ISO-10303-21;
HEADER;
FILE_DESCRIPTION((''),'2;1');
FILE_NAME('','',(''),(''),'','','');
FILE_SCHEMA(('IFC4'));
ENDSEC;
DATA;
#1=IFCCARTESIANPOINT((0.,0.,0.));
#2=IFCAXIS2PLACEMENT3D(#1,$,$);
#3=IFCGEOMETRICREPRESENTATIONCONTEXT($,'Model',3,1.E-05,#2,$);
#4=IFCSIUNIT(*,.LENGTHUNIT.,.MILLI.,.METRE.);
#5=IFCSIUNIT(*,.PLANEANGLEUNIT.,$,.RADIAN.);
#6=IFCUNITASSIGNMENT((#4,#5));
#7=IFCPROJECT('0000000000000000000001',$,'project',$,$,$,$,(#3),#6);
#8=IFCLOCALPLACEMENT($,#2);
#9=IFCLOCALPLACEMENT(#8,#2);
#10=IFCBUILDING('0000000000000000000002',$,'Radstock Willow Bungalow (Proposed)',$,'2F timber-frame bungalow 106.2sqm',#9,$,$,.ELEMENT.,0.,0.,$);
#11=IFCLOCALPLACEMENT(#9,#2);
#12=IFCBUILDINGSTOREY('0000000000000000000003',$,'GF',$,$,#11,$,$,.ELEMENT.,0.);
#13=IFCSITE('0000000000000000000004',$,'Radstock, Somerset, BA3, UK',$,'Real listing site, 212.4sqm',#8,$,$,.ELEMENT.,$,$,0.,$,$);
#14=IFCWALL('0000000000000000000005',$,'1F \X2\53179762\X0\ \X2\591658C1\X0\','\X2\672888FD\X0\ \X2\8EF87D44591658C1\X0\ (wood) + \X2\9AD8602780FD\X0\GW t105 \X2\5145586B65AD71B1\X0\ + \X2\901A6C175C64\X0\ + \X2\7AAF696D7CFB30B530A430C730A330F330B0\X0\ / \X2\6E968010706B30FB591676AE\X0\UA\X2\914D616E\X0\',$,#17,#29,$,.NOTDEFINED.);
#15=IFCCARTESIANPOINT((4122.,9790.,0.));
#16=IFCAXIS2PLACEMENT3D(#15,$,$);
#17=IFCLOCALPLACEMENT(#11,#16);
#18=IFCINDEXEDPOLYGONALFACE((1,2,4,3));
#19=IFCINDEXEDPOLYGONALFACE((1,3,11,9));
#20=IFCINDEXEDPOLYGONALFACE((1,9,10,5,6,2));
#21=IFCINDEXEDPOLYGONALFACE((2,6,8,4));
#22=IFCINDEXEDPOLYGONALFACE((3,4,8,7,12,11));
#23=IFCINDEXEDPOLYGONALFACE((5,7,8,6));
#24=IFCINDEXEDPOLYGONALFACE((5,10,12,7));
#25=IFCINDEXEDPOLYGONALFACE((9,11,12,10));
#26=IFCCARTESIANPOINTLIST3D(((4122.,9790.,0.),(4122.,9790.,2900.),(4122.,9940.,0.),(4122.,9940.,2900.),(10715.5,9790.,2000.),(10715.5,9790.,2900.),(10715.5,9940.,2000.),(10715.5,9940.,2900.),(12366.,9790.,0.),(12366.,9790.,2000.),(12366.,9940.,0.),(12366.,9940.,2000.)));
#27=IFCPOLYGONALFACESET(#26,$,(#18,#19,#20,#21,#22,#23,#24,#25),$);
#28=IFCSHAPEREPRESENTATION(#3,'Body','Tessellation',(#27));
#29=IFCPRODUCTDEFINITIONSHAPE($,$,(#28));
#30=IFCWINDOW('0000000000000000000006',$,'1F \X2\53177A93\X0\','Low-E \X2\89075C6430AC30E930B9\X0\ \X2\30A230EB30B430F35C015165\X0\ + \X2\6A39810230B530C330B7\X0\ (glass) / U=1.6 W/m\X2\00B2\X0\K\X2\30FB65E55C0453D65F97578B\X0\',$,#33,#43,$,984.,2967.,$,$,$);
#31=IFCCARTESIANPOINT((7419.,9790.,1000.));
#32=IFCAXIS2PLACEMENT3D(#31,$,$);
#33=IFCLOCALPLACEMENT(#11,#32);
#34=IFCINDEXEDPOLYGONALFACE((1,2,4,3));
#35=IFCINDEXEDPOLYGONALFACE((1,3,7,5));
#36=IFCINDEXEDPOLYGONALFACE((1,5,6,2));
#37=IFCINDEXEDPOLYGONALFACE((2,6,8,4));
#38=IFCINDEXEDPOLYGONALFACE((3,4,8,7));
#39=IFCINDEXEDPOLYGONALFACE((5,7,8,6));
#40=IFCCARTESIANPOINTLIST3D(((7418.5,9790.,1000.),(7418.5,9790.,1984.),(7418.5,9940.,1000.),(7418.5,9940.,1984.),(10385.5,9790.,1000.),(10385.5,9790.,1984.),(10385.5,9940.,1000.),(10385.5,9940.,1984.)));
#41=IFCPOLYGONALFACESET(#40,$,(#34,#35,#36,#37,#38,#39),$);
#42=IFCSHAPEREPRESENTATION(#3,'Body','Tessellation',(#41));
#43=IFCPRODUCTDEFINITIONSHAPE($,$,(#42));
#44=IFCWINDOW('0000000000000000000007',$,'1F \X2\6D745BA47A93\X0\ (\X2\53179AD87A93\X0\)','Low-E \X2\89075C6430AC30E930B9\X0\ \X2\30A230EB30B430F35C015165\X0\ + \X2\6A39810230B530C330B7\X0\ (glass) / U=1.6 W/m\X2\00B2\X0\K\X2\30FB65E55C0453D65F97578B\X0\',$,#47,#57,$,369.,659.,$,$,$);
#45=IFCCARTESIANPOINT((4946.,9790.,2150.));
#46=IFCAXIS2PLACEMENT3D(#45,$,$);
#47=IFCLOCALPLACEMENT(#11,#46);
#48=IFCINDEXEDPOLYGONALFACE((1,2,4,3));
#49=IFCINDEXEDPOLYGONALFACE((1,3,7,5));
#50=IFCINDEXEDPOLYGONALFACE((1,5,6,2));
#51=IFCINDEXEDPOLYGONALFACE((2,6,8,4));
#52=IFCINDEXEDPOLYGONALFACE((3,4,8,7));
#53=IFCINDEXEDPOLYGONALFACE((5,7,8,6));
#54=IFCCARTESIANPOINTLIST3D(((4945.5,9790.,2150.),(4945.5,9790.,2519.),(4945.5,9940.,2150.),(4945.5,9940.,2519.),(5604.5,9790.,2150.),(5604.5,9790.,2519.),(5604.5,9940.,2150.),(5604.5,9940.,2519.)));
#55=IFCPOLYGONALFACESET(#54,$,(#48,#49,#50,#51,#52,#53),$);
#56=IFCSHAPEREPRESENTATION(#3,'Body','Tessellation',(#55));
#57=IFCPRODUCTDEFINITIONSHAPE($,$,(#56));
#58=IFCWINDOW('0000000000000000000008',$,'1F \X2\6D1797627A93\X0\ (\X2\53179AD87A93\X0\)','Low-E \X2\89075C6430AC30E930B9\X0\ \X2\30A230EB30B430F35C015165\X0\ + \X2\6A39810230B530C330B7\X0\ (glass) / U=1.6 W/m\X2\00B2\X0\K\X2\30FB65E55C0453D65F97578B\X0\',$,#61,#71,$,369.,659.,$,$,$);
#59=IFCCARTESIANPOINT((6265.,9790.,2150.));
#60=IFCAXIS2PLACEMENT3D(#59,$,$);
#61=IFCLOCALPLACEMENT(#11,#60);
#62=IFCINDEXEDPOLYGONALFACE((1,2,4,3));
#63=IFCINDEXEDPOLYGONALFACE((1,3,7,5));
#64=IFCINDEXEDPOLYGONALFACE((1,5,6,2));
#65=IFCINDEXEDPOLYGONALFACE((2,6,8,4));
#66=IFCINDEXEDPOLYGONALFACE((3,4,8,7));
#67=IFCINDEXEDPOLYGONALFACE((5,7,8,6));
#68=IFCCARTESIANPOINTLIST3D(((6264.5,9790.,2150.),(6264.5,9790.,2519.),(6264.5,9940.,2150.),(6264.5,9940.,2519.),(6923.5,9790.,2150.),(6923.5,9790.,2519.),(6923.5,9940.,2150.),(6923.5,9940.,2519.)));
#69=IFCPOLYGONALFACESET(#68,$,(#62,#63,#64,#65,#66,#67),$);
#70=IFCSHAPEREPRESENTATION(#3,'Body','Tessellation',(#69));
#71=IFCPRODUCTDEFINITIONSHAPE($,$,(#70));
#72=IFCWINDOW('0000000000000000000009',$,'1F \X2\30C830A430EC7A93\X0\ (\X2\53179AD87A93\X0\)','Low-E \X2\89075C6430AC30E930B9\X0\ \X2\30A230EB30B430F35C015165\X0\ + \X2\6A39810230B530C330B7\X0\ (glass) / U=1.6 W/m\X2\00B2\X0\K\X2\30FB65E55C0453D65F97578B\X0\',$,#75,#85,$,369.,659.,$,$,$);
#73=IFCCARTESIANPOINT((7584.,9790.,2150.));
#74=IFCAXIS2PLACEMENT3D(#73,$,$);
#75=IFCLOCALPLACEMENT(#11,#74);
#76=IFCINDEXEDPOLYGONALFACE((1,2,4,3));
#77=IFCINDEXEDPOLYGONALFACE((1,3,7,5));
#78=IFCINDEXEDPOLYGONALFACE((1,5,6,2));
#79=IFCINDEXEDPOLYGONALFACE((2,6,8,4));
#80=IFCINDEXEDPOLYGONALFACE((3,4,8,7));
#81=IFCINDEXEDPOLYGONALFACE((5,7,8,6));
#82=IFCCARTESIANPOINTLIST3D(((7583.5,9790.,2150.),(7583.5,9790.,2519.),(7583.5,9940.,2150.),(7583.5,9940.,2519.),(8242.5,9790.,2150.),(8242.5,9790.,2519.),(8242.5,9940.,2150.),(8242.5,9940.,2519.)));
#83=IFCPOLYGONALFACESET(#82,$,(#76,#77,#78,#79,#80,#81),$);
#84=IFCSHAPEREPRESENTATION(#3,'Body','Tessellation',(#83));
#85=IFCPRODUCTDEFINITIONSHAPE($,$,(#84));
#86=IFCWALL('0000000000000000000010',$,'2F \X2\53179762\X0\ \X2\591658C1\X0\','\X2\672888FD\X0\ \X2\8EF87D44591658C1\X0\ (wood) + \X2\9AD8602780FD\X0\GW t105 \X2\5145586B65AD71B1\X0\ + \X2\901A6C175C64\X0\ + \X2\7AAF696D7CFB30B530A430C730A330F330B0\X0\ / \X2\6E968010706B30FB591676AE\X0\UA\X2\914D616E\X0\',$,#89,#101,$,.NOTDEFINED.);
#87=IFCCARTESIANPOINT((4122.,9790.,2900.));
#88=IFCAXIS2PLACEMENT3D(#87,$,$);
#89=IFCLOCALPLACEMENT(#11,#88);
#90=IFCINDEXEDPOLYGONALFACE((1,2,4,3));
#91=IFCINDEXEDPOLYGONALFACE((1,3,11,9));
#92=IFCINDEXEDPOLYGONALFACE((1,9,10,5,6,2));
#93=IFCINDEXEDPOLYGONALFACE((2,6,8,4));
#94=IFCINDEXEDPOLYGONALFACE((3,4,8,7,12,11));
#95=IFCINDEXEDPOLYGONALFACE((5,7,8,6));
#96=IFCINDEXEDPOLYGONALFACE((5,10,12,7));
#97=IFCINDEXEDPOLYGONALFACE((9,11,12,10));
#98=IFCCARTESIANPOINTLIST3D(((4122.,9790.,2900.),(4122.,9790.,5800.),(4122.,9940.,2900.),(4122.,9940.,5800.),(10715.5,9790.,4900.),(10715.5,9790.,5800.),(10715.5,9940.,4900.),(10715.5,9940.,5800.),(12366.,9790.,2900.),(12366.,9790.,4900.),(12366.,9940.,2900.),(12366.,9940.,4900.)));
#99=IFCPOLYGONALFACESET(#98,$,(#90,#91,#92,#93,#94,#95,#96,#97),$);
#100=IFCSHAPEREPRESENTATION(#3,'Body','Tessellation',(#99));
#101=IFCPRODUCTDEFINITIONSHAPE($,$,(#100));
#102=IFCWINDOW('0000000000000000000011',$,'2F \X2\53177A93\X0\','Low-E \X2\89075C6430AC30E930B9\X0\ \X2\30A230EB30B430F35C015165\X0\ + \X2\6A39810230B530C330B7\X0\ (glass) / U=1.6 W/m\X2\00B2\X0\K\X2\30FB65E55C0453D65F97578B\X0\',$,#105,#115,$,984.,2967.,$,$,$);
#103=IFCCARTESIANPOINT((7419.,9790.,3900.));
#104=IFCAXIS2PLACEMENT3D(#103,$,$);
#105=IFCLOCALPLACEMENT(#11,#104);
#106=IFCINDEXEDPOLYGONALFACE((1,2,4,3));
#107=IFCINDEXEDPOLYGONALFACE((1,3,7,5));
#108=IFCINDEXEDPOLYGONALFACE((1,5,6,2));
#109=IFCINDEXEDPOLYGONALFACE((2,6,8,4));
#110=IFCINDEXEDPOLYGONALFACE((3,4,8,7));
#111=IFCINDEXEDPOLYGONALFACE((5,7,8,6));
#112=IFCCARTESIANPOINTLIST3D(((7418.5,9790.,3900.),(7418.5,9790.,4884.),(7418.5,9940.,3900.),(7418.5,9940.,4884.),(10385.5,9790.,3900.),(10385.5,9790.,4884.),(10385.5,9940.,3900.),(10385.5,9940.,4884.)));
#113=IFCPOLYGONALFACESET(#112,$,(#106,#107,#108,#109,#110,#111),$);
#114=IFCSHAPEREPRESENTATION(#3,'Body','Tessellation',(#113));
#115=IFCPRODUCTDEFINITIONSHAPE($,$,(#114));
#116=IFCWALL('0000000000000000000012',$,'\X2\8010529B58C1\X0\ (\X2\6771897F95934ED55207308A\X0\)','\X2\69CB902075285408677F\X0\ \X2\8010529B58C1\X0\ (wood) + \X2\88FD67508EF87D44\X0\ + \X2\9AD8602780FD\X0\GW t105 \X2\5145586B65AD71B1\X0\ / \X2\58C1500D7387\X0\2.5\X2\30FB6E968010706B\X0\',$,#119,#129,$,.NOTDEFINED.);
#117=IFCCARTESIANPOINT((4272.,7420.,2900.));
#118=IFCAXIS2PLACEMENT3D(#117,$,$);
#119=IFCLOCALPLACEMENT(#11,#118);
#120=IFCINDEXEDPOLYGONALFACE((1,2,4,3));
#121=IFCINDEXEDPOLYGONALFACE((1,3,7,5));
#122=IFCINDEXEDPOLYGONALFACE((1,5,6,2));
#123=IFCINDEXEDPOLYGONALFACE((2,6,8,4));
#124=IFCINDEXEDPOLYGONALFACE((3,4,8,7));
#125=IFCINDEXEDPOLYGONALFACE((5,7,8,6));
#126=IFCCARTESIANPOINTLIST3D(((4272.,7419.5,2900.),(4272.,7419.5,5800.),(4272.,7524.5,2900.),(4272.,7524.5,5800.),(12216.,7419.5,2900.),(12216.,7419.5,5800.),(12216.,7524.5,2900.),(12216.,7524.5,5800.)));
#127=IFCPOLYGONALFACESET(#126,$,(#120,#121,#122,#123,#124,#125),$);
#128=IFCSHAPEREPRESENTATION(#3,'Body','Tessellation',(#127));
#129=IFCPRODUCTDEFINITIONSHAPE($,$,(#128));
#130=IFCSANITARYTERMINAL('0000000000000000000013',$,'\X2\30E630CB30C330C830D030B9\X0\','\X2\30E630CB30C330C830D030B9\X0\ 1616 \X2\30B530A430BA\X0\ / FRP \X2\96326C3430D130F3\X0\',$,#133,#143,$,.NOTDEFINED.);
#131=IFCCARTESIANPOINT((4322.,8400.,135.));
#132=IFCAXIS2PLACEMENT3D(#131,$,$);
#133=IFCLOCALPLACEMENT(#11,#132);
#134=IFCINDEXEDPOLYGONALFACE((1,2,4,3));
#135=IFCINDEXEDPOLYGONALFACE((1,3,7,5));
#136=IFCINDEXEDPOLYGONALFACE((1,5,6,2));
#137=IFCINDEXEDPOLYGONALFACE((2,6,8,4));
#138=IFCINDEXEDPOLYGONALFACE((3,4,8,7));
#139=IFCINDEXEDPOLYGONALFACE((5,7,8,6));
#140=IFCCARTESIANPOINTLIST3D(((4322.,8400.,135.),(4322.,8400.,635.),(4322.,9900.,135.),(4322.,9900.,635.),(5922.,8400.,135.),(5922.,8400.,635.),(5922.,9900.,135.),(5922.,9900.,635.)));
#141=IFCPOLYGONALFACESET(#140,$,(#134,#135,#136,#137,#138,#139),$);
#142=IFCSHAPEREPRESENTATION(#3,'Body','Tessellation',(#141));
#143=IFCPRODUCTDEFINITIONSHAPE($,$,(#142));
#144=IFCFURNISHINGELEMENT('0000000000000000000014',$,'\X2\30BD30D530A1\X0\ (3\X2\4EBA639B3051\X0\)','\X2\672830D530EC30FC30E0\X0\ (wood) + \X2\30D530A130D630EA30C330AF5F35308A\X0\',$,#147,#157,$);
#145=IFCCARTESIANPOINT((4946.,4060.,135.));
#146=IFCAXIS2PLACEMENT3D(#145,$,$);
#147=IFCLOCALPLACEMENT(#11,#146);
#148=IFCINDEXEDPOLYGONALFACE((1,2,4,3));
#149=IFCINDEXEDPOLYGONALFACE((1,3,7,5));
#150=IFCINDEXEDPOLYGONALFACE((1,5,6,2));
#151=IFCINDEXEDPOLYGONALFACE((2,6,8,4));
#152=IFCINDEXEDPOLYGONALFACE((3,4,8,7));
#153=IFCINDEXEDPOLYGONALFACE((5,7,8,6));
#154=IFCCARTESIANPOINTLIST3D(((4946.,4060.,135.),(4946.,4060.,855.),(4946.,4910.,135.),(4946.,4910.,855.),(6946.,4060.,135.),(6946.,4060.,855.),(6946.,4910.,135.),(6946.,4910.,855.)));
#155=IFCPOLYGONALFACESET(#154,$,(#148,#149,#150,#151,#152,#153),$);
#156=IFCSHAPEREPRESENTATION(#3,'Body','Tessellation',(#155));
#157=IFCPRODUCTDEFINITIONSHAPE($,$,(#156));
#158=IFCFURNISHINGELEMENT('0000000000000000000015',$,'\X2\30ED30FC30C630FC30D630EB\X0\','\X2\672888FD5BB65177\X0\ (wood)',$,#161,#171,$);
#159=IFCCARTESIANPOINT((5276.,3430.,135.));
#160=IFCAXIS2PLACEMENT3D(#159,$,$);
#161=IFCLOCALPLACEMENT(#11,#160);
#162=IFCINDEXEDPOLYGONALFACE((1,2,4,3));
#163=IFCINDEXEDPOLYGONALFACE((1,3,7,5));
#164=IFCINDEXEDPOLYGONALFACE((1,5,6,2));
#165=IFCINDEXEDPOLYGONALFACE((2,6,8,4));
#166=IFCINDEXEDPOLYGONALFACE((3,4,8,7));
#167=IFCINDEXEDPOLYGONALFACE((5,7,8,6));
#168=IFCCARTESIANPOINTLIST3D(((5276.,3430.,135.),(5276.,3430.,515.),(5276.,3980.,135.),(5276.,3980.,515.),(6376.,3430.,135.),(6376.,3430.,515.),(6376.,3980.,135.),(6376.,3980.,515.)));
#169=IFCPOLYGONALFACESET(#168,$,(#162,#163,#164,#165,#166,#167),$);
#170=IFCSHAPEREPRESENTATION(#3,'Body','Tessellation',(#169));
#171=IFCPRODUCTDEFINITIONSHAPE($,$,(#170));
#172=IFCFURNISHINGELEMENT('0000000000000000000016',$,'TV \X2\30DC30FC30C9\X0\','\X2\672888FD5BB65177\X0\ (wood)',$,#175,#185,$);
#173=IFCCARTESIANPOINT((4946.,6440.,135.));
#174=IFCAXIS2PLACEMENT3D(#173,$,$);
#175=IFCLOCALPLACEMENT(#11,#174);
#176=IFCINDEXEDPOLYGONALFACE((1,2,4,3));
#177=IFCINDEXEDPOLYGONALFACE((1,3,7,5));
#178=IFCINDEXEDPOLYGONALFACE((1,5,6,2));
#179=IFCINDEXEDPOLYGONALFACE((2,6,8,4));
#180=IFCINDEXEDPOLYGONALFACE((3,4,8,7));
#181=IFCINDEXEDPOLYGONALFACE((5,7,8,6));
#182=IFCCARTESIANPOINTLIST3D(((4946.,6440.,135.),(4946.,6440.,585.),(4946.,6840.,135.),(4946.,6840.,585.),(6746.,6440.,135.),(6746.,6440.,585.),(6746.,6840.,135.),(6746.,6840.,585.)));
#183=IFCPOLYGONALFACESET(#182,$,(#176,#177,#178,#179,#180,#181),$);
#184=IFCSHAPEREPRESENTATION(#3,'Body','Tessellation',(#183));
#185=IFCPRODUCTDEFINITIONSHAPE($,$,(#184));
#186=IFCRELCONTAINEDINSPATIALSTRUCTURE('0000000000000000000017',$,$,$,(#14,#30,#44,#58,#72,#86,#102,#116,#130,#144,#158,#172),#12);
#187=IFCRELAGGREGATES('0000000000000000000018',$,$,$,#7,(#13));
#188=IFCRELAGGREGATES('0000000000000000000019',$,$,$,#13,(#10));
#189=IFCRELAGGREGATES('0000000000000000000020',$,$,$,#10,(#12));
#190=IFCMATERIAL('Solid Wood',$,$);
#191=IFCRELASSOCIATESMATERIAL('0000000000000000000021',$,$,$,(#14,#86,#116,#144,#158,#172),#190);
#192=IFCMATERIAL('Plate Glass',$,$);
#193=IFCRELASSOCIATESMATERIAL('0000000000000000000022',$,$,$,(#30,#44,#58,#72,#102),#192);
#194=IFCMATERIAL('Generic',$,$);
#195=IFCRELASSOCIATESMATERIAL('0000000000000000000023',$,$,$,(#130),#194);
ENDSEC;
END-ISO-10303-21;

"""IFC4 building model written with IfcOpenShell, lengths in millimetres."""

from ifc_helpers import new_model, si_unit, frame, frame_2d, origin, place, context, project, spatial, rectangle, extrude, material, element, fill, save


model = new_model("IFC4")

# Units and contexts
model_context = context("Model", 3, precision=1e-05, world=origin())
ifc_project = project(units=[si_unit("LENGTHUNIT", "METRE", prefix="MILLI"), si_unit("PLANEANGLEUNIT", "RADIAN")], contexts=[model_context])

# Site, building, storey
site_placement = place(None, origin())
site = spatial("IfcSite", under=ifc_project, at=site_placement, Name="Radstock, Somerset, BA3, UK", ObjectType="Real listing site, 212.4sqm", CompositionType="ELEMENT", RefElevation=0.0)
building_placement = place(site_placement, origin())
building = spatial("IfcBuilding", under=site, at=building_placement, Name="Radstock Willow Bungalow (Proposed)", ObjectType="2F timber-frame bungalow 106.2sqm", CompositionType="ELEMENT", ElevationOfRefHeight=0.0, ElevationOfTerrain=0.0)
storey_placement = place(building_placement, origin())
storey = spatial("IfcBuildingStorey", under=building, at=storey_placement, Name="GF", CompositionType="ELEMENT", Elevation=0.0)

# Wall, openings, windows
ifc_material_1 = material(Name="Solid Wood")
wall_1_placement = place(storey_placement, frame((4122.0, 9790.0, 0.0)))
wall_1 = element("IfcWall", 1, at=wall_1_placement, inside=storey, material=ifc_material_1, Name="1F 北面 外壁", Description="木製 軸組外壁 (wood) + 高性能GW t105 充填断熱 + 通気層 + 窯業系サイディング / 準耐火・外皮UA配慮", PredefinedType="NOTDEFINED", context=model_context, shape_type="SweptSolid", body=[
    extrude(rectangle(XDim=8244.0, YDim=150.0, at=frame_2d((4122.0, 75.0))), frame((4122.0, 9790.0, 0.0)), (0.0, 0.0, 1.0), 2900.0),
])
opening_1_placement = place(storey_placement, frame((7419.0, 9790.0, 1000.0)))
opening_1 = element("IfcOpeningElement", 2, at=opening_1_placement, cuts=wall_1, PredefinedType="NOTDEFINED", context=model_context, shape_type="SweptSolid", body=[
    extrude(rectangle(XDim=2967.0, YDim=150.0, at=frame_2d((1483.0, 75.0))), frame((7419.0, 9790.0, 1000.0)), (0.0, 0.0, 1.0), 984.0),
])
opening_2_placement = place(storey_placement, frame((4946.0, 9790.0, 2150.0)))
opening_2 = element("IfcOpeningElement", 3, at=opening_2_placement, cuts=wall_1, PredefinedType="NOTDEFINED", context=model_context, shape_type="SweptSolid", body=[
    extrude(rectangle(XDim=659.0, YDim=150.0, at=frame_2d((329.0, 75.0))), frame((4946.0, 9790.0, 2150.0)), (0.0, 0.0, 1.0), 369.0),
])
opening_3_placement = place(storey_placement, frame((6265.0, 9790.0, 2150.0)))
opening_3 = element("IfcOpeningElement", 4, at=opening_3_placement, cuts=wall_1, PredefinedType="NOTDEFINED", context=model_context, shape_type="SweptSolid", body=[
    extrude(rectangle(XDim=659.0, YDim=150.0, at=frame_2d((329.0, 75.0))), frame((6265.0, 9790.0, 2150.0)), (0.0, 0.0, 1.0), 369.0),
])
opening_4_placement = place(storey_placement, frame((7584.0, 9790.0, 2150.0)))
opening_4 = element("IfcOpeningElement", 5, at=opening_4_placement, cuts=wall_1, PredefinedType="NOTDEFINED", context=model_context, shape_type="SweptSolid", body=[
    extrude(rectangle(XDim=659.0, YDim=150.0, at=frame_2d((329.0, 75.0))), frame((7584.0, 9790.0, 2150.0)), (0.0, 0.0, 1.0), 369.0),
])
ifc_material_2 = material(Name="Plate Glass")
window_1_placement = place(storey_placement, frame((7419.0, 9790.0, 1000.0)))
window_1 = element("IfcWindow", 6, at=window_1_placement, inside=storey, material=ifc_material_2, Name="1F 北窓", Description="Low-E 複層ガラス アルゴン封入 + 樹脂サッシ (glass) / U=1.6 W/m²K・日射取得型", OverallHeight=984.0, OverallWidth=2967.0, context=model_context, shape_type="SweptSolid", body=[
    extrude(rectangle(XDim=2967.0, YDim=150.0, at=frame_2d((1483.0, 75.0))), frame((7419.0, 9790.0, 1000.0)), (0.0, 0.0, 1.0), 984.0),
])
fill(opening_1, window_1)
window_2_placement = place(storey_placement, frame((4946.0, 9790.0, 2150.0)))
window_2 = element("IfcWindow", 7, at=window_2_placement, inside=storey, material=ifc_material_2, Name="1F 浴室窓 (北高窓)", Description="Low-E 複層ガラス アルゴン封入 + 樹脂サッシ (glass) / U=1.6 W/m²K・日射取得型", OverallHeight=369.0, OverallWidth=659.0, context=model_context, shape_type="SweptSolid", body=[
    extrude(rectangle(XDim=659.0, YDim=150.0, at=frame_2d((329.0, 75.0))), frame((4946.0, 9790.0, 2150.0)), (0.0, 0.0, 1.0), 369.0),
])
fill(opening_2, window_2)
window_3_placement = place(storey_placement, frame((6265.0, 9790.0, 2150.0)))
window_3 = element("IfcWindow", 8, at=window_3_placement, inside=storey, material=ifc_material_2, Name="1F 洗面窓 (北高窓)", Description="Low-E 複層ガラス アルゴン封入 + 樹脂サッシ (glass) / U=1.6 W/m²K・日射取得型", OverallHeight=369.0, OverallWidth=659.0, context=model_context, shape_type="SweptSolid", body=[
    extrude(rectangle(XDim=659.0, YDim=150.0, at=frame_2d((329.0, 75.0))), frame((6265.0, 9790.0, 2150.0)), (0.0, 0.0, 1.0), 369.0),
])
fill(opening_3, window_3)
window_4_placement = place(storey_placement, frame((7584.0, 9790.0, 2150.0)))
window_4 = element("IfcWindow", 9, at=window_4_placement, inside=storey, material=ifc_material_2, Name="1F トイレ窓 (北高窓)", Description="Low-E 複層ガラス アルゴン封入 + 樹脂サッシ (glass) / U=1.6 W/m²K・日射取得型", OverallHeight=369.0, OverallWidth=659.0, context=model_context, shape_type="SweptSolid", body=[
    extrude(rectangle(XDim=659.0, YDim=150.0, at=frame_2d((329.0, 75.0))), frame((7584.0, 9790.0, 2150.0)), (0.0, 0.0, 1.0), 369.0),
])
fill(opening_4, window_4)

# Wall, opening, window
wall_2_placement = place(storey_placement, frame((4122.0, 9790.0, 2900.0)))
wall_2 = element("IfcWall", 10, at=wall_2_placement, inside=storey, material=ifc_material_1, Name="2F 北面 外壁", Description="木製 軸組外壁 (wood) + 高性能GW t105 充填断熱 + 通気層 + 窯業系サイディング / 準耐火・外皮UA配慮", PredefinedType="NOTDEFINED", context=model_context, shape_type="SweptSolid", body=[
    extrude(rectangle(XDim=8244.0, YDim=150.0, at=frame_2d((4122.0, 75.0))), frame((4122.0, 9790.0, 2900.0)), (0.0, 0.0, 1.0), 2900.0),
])
opening_5_placement = place(storey_placement, frame((7419.0, 9790.0, 3900.0)))
opening_5 = element("IfcOpeningElement", 11, at=opening_5_placement, cuts=wall_2, PredefinedType="NOTDEFINED", context=model_context, shape_type="SweptSolid", body=[
    extrude(rectangle(XDim=2967.0, YDim=150.0, at=frame_2d((1483.0, 75.0))), frame((7419.0, 9790.0, 3900.0)), (0.0, 0.0, 1.0), 984.0),
])
window_5_placement = place(storey_placement, frame((7419.0, 9790.0, 3900.0)))
window_5 = element("IfcWindow", 12, at=window_5_placement, inside=storey, material=ifc_material_2, Name="2F 北窓", Description="Low-E 複層ガラス アルゴン封入 + 樹脂サッシ (glass) / U=1.6 W/m²K・日射取得型", OverallHeight=984.0, OverallWidth=2967.0, context=model_context, shape_type="SweptSolid", body=[
    extrude(rectangle(XDim=2967.0, YDim=150.0, at=frame_2d((1483.0, 75.0))), frame((7419.0, 9790.0, 3900.0)), (0.0, 0.0, 1.0), 984.0),
])
fill(opening_5, window_5)

# Wall
wall_3_placement = place(storey_placement, frame((4272.0, 7420.0, 2900.0)))
element("IfcWall", 13, at=wall_3_placement, inside=storey, material=ifc_material_1, Name="耐力壁 (東西間仕切り)", Description="構造用合板 耐力壁 (wood) + 製材軸組 + 高性能GW t105 充填断熱 / 壁倍率2.5・準耐火", PredefinedType="NOTDEFINED", context=model_context, shape_type="SweptSolid", body=[
    extrude(rectangle(XDim=7944.0, YDim=105.0, at=frame_2d((3972.0, 52.0))), frame((4272.0, 7420.0, 2900.0)), (0.0, 0.0, 1.0), 2900.0),
])

# Sanitary terminal
ifc_material_3 = material(Name="Generic")
sanitary_terminal_placement = place(storey_placement, frame((4322.0, 8400.0, 135.0)))
element("IfcSanitaryTerminal", 14, at=sanitary_terminal_placement, inside=storey, material=ifc_material_3, Name="ユニットバス", Description="ユニットバス 1616 サイズ / FRP 防水パン", PredefinedType="NOTDEFINED", context=model_context, shape_type="SweptSolid", body=[
    extrude(rectangle(XDim=1600.0, YDim=1500.0, at=frame_2d((800.0, 750.0))), frame((4322.0, 8400.0, 135.0)), (0.0, 0.0, 1.0), 500.0),
])

# Furnishing elements
furnishing_1_placement = place(storey_placement, frame((4946.0, 4060.0, 135.0)))
element("IfcFurnishingElement", 15, at=furnishing_1_placement, inside=storey, material=ifc_material_1, Name="ソファ (3人掛け)", Description="木フレーム (wood) + ファブリック張り", context=model_context, shape_type="SweptSolid", body=[
    extrude(rectangle(XDim=2000.0, YDim=850.0, at=frame_2d((1000.0, 425.0))), frame((4946.0, 4060.0, 135.0)), (0.0, 0.0, 1.0), 720.0),
])
furnishing_2_placement = place(storey_placement, frame((5276.0, 3430.0, 135.0)))
element("IfcFurnishingElement", 16, at=furnishing_2_placement, inside=storey, material=ifc_material_1, Name="ローテーブル", Description="木製家具 (wood)", context=model_context, shape_type="SweptSolid", body=[
    extrude(rectangle(XDim=1100.0, YDim=550.0, at=frame_2d((550.0, 275.0))), frame((5276.0, 3430.0, 135.0)), (0.0, 0.0, 1.0), 380.0),
])
furnishing_3_placement = place(storey_placement, frame((4946.0, 6440.0, 135.0)))
element("IfcFurnishingElement", 17, at=furnishing_3_placement, inside=storey, material=ifc_material_1, Name="TV ボード", Description="木製家具 (wood)", context=model_context, shape_type="SweptSolid", body=[
    extrude(rectangle(XDim=1800.0, YDim=400.0, at=frame_2d((900.0, 200.0))), frame((4946.0, 6440.0, 135.0)), (0.0, 0.0, 1.0), 450.0),
])

save(model, "model.ifc")
